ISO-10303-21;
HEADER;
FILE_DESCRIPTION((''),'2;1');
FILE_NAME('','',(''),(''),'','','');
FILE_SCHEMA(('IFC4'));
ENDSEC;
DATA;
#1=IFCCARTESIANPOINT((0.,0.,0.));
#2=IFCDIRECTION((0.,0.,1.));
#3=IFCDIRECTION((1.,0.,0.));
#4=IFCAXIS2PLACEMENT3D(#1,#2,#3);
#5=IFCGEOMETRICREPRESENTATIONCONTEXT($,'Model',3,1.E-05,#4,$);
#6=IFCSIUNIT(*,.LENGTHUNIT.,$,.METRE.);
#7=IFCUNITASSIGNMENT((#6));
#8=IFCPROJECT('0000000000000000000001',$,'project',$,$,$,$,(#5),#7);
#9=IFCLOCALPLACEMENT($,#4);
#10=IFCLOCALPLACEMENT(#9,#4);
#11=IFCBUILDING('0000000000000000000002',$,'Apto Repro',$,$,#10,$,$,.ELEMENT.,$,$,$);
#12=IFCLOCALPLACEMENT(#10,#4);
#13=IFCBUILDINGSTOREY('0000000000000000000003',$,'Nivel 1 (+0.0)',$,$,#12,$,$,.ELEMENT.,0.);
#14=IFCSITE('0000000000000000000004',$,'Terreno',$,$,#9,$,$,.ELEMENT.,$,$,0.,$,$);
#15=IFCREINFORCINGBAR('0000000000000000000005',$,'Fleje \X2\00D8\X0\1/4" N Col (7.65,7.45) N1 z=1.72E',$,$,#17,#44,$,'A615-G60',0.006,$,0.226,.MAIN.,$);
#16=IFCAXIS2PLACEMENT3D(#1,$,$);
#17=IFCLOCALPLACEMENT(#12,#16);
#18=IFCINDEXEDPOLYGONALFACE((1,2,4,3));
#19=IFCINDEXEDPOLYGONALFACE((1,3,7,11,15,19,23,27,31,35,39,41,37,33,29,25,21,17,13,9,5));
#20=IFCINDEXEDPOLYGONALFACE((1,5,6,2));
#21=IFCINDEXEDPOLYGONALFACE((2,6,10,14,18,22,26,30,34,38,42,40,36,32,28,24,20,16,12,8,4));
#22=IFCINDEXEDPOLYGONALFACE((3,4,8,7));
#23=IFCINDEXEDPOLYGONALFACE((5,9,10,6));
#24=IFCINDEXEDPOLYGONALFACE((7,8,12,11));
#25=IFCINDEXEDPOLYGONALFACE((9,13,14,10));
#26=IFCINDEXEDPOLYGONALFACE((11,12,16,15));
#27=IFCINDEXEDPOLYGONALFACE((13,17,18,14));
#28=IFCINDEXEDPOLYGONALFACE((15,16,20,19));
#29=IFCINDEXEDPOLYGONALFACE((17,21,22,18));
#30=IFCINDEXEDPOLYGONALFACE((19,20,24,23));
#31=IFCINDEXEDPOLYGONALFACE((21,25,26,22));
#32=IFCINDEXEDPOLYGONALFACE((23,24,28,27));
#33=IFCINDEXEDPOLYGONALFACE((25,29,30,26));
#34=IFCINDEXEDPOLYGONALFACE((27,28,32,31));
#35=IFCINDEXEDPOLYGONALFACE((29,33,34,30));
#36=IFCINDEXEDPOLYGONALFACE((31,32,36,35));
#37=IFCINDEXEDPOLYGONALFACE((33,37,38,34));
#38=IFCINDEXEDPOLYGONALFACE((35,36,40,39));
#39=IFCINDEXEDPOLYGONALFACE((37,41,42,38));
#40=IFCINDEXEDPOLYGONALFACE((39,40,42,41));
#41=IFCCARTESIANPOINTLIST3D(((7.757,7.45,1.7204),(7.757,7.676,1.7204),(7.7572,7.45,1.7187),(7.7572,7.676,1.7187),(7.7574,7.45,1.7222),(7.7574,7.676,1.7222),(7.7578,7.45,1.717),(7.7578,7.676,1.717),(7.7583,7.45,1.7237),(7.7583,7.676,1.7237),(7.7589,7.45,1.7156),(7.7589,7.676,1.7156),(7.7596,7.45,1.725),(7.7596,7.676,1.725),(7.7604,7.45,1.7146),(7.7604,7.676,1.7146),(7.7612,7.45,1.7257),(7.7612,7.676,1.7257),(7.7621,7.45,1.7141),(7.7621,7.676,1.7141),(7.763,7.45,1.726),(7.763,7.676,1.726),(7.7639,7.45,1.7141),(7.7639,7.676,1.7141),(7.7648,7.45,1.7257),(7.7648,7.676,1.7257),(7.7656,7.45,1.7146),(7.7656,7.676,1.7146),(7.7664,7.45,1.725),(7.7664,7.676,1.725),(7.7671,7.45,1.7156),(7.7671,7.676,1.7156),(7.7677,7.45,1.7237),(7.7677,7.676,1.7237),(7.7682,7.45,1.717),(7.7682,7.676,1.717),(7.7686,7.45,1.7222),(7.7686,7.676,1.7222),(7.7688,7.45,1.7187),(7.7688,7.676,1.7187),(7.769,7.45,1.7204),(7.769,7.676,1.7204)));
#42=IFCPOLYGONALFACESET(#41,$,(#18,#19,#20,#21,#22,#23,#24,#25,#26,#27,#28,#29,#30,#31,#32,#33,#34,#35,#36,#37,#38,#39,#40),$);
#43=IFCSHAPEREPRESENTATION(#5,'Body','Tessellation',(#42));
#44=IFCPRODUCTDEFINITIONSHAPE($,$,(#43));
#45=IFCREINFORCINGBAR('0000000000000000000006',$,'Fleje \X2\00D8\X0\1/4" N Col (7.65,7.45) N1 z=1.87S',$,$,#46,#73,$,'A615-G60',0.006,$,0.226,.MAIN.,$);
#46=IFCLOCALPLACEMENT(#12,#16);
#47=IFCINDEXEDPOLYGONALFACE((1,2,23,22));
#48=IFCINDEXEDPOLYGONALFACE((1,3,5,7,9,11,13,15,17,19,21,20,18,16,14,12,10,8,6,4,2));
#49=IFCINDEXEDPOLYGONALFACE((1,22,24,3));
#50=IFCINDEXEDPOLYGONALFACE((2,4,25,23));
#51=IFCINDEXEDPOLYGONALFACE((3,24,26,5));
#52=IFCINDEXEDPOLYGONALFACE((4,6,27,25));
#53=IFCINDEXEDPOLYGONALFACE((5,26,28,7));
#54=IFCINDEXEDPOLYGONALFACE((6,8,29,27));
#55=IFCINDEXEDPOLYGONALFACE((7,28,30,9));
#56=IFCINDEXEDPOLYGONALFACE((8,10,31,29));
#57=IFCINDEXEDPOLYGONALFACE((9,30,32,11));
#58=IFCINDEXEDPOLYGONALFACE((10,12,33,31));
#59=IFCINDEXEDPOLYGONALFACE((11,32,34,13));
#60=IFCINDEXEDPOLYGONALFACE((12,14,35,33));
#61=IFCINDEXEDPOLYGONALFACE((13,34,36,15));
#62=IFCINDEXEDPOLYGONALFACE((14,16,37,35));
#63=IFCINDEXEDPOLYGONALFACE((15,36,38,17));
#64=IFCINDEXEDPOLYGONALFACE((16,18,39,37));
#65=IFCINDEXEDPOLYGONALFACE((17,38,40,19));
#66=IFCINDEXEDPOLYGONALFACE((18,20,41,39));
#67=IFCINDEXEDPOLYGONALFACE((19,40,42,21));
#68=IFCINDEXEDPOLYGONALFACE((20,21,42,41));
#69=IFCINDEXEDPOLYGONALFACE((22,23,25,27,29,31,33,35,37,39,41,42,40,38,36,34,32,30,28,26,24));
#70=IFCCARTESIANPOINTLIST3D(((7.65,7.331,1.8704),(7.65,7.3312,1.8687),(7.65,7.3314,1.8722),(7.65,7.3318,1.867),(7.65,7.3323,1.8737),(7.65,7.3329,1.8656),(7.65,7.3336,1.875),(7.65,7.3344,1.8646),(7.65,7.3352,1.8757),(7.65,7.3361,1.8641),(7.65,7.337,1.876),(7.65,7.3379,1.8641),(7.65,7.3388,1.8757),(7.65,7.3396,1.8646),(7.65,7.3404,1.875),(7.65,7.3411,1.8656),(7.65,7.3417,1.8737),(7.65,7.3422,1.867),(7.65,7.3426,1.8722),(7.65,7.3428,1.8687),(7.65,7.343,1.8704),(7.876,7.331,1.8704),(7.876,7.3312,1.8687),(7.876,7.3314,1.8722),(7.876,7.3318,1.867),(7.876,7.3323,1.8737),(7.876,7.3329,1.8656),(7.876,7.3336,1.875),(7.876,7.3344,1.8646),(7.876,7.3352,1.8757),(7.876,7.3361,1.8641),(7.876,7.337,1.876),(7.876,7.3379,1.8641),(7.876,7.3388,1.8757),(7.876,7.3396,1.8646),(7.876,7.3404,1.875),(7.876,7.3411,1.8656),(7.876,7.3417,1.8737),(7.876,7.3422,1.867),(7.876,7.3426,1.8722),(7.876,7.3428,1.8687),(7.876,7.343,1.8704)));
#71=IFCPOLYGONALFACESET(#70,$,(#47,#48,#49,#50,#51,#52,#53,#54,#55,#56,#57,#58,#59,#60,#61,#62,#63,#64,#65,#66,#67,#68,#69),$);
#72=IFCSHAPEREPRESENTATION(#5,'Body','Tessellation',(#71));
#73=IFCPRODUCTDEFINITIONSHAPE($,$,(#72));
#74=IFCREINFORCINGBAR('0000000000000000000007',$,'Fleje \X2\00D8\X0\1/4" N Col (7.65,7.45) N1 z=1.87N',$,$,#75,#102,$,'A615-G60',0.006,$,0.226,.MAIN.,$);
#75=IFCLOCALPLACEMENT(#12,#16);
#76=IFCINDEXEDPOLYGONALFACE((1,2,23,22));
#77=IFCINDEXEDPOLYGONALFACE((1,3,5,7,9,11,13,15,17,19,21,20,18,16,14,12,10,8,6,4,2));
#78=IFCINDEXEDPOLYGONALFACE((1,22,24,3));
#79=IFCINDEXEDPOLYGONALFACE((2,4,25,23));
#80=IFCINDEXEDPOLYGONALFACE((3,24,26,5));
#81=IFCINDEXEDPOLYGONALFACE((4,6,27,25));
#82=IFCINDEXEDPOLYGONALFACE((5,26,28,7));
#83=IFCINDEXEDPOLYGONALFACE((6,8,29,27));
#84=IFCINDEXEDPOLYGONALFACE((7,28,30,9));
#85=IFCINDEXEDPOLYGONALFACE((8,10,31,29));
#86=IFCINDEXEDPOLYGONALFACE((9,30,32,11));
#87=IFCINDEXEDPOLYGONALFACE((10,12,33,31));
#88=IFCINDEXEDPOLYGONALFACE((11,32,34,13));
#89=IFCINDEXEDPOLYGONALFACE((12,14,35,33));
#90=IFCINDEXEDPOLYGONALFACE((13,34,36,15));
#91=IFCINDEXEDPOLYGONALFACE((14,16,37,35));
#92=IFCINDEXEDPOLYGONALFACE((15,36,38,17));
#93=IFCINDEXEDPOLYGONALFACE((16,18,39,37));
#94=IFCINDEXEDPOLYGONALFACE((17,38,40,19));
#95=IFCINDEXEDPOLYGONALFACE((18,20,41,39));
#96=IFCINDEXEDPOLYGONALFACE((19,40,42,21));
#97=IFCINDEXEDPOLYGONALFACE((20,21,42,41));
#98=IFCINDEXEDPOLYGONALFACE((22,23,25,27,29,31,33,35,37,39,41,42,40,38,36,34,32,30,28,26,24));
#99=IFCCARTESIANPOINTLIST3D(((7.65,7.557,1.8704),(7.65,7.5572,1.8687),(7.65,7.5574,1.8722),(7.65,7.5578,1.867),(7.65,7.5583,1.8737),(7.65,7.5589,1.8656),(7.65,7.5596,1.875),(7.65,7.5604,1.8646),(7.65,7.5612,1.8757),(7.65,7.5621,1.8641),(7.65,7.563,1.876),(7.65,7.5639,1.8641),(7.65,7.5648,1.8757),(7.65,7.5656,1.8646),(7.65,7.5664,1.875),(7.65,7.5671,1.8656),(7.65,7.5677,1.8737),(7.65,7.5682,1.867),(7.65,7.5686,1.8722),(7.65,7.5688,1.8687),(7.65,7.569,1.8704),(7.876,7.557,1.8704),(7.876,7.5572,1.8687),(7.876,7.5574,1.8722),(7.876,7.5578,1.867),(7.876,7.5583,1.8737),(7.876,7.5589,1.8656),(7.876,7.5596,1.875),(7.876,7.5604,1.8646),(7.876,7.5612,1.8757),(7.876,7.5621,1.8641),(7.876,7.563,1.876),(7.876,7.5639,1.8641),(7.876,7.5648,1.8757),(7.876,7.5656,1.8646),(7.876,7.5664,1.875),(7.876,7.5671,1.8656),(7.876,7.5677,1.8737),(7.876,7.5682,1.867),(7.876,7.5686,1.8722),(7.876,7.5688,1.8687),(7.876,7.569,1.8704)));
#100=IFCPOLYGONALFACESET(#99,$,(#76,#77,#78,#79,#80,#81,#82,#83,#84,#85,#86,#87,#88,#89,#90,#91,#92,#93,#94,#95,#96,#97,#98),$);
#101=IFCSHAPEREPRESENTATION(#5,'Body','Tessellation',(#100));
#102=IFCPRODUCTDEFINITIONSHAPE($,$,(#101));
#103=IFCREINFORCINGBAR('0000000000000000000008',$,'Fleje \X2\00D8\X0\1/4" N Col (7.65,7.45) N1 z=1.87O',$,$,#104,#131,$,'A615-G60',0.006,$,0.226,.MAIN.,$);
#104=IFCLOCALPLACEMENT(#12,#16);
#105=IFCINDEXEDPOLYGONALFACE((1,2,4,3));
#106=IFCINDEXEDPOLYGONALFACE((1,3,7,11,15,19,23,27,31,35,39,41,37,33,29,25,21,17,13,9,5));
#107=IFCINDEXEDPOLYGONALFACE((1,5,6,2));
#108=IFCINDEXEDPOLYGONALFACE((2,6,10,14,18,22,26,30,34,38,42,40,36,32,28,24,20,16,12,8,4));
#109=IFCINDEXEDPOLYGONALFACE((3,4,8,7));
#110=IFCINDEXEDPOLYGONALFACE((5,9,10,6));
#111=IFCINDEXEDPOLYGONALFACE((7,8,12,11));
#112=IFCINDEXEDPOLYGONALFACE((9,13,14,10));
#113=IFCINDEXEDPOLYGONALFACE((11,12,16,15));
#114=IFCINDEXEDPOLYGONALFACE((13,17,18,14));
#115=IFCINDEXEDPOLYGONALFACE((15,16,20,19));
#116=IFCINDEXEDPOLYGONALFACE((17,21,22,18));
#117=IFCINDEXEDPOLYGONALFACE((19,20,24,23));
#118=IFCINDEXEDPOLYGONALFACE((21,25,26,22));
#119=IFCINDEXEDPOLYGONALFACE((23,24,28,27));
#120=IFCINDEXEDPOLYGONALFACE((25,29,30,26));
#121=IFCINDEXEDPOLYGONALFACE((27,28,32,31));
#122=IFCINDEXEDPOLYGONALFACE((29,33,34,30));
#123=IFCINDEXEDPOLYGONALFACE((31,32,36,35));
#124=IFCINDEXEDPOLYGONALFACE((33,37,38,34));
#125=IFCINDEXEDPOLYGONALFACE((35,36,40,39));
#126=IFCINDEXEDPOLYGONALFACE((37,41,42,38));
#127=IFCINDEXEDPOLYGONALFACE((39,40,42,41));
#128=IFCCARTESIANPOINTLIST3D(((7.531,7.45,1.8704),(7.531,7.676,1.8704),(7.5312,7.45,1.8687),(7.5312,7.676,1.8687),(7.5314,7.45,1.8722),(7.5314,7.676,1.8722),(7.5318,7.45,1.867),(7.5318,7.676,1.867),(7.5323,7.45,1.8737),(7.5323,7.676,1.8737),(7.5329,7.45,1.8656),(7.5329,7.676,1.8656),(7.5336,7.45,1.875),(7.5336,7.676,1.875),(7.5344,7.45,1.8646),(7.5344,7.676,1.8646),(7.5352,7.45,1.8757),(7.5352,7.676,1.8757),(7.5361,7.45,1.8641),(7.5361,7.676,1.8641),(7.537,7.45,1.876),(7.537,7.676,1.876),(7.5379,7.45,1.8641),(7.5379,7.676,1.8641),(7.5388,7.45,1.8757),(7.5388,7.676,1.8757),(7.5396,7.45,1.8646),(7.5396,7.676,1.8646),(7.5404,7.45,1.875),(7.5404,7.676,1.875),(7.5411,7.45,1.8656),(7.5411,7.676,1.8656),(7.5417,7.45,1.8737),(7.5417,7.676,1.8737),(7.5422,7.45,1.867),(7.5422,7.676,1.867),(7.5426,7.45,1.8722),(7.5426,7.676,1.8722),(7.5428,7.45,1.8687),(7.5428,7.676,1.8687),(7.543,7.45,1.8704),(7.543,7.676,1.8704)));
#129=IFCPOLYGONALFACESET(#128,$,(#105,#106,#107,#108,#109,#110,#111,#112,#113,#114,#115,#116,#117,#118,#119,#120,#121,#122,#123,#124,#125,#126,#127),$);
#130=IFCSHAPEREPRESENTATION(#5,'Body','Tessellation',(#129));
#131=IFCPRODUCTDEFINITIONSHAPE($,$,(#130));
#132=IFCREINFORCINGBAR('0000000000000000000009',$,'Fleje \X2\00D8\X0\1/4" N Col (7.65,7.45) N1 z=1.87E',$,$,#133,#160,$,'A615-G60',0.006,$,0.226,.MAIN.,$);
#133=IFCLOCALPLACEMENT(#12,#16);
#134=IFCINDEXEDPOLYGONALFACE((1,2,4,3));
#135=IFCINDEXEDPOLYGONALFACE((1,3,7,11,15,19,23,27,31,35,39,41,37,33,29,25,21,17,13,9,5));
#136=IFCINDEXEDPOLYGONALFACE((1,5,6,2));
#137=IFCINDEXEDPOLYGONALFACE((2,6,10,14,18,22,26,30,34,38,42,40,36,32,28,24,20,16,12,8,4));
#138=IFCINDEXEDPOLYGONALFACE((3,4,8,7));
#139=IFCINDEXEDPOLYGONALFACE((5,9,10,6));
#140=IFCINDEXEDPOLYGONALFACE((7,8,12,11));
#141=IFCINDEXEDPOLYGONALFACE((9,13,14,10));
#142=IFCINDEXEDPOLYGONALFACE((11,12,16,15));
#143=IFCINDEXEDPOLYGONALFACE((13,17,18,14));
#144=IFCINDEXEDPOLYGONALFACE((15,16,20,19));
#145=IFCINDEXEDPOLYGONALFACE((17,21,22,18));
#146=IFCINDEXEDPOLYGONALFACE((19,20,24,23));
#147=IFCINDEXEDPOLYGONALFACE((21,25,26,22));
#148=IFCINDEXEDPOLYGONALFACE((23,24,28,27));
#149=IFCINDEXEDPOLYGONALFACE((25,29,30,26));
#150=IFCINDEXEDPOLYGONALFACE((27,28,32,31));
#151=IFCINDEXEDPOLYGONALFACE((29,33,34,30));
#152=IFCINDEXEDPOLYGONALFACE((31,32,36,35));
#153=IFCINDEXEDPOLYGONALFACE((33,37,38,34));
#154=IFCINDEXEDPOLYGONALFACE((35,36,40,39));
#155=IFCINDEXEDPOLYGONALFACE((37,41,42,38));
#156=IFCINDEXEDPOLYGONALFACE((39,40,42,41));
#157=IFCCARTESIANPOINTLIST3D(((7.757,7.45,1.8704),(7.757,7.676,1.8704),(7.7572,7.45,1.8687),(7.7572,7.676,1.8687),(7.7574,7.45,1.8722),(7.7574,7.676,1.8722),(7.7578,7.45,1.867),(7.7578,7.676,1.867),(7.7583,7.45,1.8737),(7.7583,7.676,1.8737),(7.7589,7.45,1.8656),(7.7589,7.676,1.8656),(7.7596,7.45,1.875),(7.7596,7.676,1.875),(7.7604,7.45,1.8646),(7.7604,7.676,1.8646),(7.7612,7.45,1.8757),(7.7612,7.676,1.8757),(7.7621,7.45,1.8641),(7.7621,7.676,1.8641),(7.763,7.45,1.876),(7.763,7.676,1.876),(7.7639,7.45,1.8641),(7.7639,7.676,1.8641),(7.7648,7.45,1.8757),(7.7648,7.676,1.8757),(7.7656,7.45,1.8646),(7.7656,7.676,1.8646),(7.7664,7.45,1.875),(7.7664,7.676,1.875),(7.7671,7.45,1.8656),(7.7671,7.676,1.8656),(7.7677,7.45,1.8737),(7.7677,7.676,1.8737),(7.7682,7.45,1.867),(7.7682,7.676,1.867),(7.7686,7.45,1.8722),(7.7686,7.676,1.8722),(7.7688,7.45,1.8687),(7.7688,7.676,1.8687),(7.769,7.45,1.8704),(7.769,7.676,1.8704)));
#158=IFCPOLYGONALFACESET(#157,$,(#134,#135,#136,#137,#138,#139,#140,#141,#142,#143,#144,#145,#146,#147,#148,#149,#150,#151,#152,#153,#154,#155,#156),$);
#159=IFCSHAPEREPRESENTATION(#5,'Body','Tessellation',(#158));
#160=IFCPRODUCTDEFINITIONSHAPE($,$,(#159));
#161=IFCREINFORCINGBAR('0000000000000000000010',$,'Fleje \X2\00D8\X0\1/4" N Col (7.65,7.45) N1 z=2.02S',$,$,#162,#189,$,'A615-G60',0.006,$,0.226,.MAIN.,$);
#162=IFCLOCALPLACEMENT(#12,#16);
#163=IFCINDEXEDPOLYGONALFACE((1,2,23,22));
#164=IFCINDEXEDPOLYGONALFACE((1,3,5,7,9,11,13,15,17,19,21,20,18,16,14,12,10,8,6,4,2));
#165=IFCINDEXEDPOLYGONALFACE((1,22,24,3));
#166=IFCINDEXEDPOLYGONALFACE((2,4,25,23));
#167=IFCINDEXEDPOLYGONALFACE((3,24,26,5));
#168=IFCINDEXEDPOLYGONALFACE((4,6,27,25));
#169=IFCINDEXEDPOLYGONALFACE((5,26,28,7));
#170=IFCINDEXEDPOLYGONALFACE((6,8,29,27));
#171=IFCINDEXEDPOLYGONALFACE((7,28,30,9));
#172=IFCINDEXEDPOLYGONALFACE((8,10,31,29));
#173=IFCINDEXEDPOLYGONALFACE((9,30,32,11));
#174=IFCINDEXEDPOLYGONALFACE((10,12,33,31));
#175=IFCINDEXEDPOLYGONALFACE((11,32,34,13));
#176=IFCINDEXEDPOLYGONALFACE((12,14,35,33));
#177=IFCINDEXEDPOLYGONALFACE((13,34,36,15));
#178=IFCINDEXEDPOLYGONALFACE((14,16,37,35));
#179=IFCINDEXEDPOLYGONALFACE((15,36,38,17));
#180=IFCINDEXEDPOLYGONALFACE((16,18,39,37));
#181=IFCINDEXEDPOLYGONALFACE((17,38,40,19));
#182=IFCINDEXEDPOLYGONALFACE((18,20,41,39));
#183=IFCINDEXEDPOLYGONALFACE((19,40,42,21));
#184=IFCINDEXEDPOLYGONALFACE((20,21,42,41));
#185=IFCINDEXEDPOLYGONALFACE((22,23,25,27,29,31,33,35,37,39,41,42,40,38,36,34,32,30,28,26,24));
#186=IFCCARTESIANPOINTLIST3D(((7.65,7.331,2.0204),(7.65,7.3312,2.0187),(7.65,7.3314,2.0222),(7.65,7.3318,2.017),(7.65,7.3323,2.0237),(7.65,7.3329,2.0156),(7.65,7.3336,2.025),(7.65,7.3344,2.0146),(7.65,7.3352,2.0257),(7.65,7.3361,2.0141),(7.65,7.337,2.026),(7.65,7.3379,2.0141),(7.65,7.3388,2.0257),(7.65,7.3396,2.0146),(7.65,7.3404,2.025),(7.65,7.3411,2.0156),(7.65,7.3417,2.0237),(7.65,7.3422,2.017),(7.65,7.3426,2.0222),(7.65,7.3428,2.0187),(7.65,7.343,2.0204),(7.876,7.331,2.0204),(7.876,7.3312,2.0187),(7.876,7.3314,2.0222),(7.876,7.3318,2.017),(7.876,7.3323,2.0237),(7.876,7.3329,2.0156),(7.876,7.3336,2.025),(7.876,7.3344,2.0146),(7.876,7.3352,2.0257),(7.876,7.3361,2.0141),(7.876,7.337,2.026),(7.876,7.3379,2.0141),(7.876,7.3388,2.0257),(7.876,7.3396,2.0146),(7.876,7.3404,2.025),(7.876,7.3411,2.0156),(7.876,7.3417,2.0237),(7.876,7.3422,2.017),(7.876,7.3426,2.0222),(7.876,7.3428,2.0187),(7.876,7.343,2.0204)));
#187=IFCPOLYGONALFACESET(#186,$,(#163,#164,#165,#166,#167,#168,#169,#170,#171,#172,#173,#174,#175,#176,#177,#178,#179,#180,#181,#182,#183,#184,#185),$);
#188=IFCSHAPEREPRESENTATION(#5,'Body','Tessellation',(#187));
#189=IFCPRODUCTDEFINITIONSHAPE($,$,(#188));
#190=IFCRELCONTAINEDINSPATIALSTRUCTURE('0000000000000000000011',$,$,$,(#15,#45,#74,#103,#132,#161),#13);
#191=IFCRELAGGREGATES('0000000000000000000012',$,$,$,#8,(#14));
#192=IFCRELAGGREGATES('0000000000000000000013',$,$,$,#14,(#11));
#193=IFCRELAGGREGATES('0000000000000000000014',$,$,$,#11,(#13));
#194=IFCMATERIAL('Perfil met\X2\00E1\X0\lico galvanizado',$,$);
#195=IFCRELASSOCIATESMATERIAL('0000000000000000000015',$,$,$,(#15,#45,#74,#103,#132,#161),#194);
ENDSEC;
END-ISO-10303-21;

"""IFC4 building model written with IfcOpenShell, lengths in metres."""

from ifc_helpers import new_model, si_unit, frame, origin_with_axes, origin_2d_with_axis, place, context, project, spatial, circle, extrude, material, element, save


model = new_model("IFC4")

# Units and contexts
model_context = context("Model", 3, precision=1e-05, world=origin_with_axes())
ifc_project = project(units=[si_unit("LENGTHUNIT", "METRE")], contexts=[model_context])

# Site, building, storey
site_placement = place(None, origin_with_axes())
site = spatial("IfcSite", under=ifc_project, at=site_placement, Name="Terreno", CompositionType="ELEMENT", RefElevation=0.0)
building_placement = place(site_placement, origin_with_axes())
building = spatial("IfcBuilding", under=site, at=building_placement, Name="Apto Repro", CompositionType="ELEMENT")
storey_placement = place(building_placement, origin_with_axes())
storey = spatial("IfcBuildingStorey", under=building, at=storey_placement, Name="Nivel 1 (+0.0)", CompositionType="ELEMENT", Elevation=0.0)

# Reinforcing bars
ifc_material = material(Name="Perfil metálico galvanizado")
reinforcing_bar_1_placement = place(storey_placement, origin_with_axes())
element("IfcReinforcingBar", 1, at=reinforcing_bar_1_placement, inside=storey, material=ifc_material, Name="Fleje Ø1/4\" N Col (7.65,7.45) N1 z=1.72E", SteelGrade="A615-G60", BarLength=0.226, NominalDiameter=0.006, PredefinedType="MAIN", context=model_context, shape_type="SweptSolid", body=[
    extrude(circle(Radius=0.006, at=origin_2d_with_axis()), frame((7.763, 7.45, 1.72), z_axis=(0.0, 1.0, 0.0), x_axis=(0.0, 0.0, 1.0)), (0.0, 0.0, 1.0), 0.226),
])
reinforcing_bar_2_placement = place(storey_placement, origin_with_axes())
element("IfcReinforcingBar", 2, at=reinforcing_bar_2_placement, inside=storey, material=ifc_material, Name="Fleje Ø1/4\" N Col (7.65,7.45) N1 z=1.87S", SteelGrade="A615-G60", BarLength=0.226, NominalDiameter=0.006, PredefinedType="MAIN", context=model_context, shape_type="SweptSolid", body=[
    extrude(circle(Radius=0.006, at=origin_2d_with_axis()), frame((7.65, 7.337, 1.87), z_axis=(1.0, 0.0, 0.0), x_axis=(0.0, 0.0, 1.0)), (0.0, 0.0, 1.0), 0.226),
])
reinforcing_bar_3_placement = place(storey_placement, origin_with_axes())
element("IfcReinforcingBar", 3, at=reinforcing_bar_3_placement, inside=storey, material=ifc_material, Name="Fleje Ø1/4\" N Col (7.65,7.45) N1 z=1.87N", SteelGrade="A615-G60", BarLength=0.226, NominalDiameter=0.006, PredefinedType="MAIN", context=model_context, shape_type="SweptSolid", body=[
    extrude(circle(Radius=0.006, at=origin_2d_with_axis()), frame((7.65, 7.563, 1.87), z_axis=(1.0, 0.0, 0.0), x_axis=(0.0, 0.0, 1.0)), (0.0, 0.0, 1.0), 0.226),
])
reinforcing_bar_4_placement = place(storey_placement, origin_with_axes())
element("IfcReinforcingBar", 4, at=reinforcing_bar_4_placement, inside=storey, material=ifc_material, Name="Fleje Ø1/4\" N Col (7.65,7.45) N1 z=1.87O", SteelGrade="A615-G60", BarLength=0.226, NominalDiameter=0.006, PredefinedType="MAIN", context=model_context, shape_type="SweptSolid", body=[
    extrude(circle(Radius=0.006, at=origin_2d_with_axis()), frame((7.537, 7.45, 1.87), z_axis=(0.0, 1.0, 0.0), x_axis=(0.0, 0.0, 1.0)), (0.0, 0.0, 1.0), 0.226),
])
reinforcing_bar_5_placement = place(storey_placement, origin_with_axes())
element("IfcReinforcingBar", 5, at=reinforcing_bar_5_placement, inside=storey, material=ifc_material, Name="Fleje Ø1/4\" N Col (7.65,7.45) N1 z=1.87E", SteelGrade="A615-G60", BarLength=0.226, NominalDiameter=0.006, PredefinedType="MAIN", context=model_context, shape_type="SweptSolid", body=[
    extrude(circle(Radius=0.006, at=origin_2d_with_axis()), frame((7.763, 7.45, 1.87), z_axis=(0.0, 1.0, 0.0), x_axis=(0.0, 0.0, 1.0)), (0.0, 0.0, 1.0), 0.226),
])
reinforcing_bar_6_placement = place(storey_placement, origin_with_axes())
element("IfcReinforcingBar", 6, at=reinforcing_bar_6_placement, inside=storey, material=ifc_material, Name="Fleje Ø1/4\" N Col (7.65,7.45) N1 z=2.02S", SteelGrade="A615-G60", BarLength=0.226, NominalDiameter=0.006, PredefinedType="MAIN", context=model_context, shape_type="SweptSolid", body=[
    extrude(circle(Radius=0.006, at=origin_2d_with_axis()), frame((7.65, 7.337, 2.02), z_axis=(1.0, 0.0, 0.0), x_axis=(0.0, 0.0, 1.0)), (0.0, 0.0, 1.0), 0.226),
])

save(model, "model.ifc")
